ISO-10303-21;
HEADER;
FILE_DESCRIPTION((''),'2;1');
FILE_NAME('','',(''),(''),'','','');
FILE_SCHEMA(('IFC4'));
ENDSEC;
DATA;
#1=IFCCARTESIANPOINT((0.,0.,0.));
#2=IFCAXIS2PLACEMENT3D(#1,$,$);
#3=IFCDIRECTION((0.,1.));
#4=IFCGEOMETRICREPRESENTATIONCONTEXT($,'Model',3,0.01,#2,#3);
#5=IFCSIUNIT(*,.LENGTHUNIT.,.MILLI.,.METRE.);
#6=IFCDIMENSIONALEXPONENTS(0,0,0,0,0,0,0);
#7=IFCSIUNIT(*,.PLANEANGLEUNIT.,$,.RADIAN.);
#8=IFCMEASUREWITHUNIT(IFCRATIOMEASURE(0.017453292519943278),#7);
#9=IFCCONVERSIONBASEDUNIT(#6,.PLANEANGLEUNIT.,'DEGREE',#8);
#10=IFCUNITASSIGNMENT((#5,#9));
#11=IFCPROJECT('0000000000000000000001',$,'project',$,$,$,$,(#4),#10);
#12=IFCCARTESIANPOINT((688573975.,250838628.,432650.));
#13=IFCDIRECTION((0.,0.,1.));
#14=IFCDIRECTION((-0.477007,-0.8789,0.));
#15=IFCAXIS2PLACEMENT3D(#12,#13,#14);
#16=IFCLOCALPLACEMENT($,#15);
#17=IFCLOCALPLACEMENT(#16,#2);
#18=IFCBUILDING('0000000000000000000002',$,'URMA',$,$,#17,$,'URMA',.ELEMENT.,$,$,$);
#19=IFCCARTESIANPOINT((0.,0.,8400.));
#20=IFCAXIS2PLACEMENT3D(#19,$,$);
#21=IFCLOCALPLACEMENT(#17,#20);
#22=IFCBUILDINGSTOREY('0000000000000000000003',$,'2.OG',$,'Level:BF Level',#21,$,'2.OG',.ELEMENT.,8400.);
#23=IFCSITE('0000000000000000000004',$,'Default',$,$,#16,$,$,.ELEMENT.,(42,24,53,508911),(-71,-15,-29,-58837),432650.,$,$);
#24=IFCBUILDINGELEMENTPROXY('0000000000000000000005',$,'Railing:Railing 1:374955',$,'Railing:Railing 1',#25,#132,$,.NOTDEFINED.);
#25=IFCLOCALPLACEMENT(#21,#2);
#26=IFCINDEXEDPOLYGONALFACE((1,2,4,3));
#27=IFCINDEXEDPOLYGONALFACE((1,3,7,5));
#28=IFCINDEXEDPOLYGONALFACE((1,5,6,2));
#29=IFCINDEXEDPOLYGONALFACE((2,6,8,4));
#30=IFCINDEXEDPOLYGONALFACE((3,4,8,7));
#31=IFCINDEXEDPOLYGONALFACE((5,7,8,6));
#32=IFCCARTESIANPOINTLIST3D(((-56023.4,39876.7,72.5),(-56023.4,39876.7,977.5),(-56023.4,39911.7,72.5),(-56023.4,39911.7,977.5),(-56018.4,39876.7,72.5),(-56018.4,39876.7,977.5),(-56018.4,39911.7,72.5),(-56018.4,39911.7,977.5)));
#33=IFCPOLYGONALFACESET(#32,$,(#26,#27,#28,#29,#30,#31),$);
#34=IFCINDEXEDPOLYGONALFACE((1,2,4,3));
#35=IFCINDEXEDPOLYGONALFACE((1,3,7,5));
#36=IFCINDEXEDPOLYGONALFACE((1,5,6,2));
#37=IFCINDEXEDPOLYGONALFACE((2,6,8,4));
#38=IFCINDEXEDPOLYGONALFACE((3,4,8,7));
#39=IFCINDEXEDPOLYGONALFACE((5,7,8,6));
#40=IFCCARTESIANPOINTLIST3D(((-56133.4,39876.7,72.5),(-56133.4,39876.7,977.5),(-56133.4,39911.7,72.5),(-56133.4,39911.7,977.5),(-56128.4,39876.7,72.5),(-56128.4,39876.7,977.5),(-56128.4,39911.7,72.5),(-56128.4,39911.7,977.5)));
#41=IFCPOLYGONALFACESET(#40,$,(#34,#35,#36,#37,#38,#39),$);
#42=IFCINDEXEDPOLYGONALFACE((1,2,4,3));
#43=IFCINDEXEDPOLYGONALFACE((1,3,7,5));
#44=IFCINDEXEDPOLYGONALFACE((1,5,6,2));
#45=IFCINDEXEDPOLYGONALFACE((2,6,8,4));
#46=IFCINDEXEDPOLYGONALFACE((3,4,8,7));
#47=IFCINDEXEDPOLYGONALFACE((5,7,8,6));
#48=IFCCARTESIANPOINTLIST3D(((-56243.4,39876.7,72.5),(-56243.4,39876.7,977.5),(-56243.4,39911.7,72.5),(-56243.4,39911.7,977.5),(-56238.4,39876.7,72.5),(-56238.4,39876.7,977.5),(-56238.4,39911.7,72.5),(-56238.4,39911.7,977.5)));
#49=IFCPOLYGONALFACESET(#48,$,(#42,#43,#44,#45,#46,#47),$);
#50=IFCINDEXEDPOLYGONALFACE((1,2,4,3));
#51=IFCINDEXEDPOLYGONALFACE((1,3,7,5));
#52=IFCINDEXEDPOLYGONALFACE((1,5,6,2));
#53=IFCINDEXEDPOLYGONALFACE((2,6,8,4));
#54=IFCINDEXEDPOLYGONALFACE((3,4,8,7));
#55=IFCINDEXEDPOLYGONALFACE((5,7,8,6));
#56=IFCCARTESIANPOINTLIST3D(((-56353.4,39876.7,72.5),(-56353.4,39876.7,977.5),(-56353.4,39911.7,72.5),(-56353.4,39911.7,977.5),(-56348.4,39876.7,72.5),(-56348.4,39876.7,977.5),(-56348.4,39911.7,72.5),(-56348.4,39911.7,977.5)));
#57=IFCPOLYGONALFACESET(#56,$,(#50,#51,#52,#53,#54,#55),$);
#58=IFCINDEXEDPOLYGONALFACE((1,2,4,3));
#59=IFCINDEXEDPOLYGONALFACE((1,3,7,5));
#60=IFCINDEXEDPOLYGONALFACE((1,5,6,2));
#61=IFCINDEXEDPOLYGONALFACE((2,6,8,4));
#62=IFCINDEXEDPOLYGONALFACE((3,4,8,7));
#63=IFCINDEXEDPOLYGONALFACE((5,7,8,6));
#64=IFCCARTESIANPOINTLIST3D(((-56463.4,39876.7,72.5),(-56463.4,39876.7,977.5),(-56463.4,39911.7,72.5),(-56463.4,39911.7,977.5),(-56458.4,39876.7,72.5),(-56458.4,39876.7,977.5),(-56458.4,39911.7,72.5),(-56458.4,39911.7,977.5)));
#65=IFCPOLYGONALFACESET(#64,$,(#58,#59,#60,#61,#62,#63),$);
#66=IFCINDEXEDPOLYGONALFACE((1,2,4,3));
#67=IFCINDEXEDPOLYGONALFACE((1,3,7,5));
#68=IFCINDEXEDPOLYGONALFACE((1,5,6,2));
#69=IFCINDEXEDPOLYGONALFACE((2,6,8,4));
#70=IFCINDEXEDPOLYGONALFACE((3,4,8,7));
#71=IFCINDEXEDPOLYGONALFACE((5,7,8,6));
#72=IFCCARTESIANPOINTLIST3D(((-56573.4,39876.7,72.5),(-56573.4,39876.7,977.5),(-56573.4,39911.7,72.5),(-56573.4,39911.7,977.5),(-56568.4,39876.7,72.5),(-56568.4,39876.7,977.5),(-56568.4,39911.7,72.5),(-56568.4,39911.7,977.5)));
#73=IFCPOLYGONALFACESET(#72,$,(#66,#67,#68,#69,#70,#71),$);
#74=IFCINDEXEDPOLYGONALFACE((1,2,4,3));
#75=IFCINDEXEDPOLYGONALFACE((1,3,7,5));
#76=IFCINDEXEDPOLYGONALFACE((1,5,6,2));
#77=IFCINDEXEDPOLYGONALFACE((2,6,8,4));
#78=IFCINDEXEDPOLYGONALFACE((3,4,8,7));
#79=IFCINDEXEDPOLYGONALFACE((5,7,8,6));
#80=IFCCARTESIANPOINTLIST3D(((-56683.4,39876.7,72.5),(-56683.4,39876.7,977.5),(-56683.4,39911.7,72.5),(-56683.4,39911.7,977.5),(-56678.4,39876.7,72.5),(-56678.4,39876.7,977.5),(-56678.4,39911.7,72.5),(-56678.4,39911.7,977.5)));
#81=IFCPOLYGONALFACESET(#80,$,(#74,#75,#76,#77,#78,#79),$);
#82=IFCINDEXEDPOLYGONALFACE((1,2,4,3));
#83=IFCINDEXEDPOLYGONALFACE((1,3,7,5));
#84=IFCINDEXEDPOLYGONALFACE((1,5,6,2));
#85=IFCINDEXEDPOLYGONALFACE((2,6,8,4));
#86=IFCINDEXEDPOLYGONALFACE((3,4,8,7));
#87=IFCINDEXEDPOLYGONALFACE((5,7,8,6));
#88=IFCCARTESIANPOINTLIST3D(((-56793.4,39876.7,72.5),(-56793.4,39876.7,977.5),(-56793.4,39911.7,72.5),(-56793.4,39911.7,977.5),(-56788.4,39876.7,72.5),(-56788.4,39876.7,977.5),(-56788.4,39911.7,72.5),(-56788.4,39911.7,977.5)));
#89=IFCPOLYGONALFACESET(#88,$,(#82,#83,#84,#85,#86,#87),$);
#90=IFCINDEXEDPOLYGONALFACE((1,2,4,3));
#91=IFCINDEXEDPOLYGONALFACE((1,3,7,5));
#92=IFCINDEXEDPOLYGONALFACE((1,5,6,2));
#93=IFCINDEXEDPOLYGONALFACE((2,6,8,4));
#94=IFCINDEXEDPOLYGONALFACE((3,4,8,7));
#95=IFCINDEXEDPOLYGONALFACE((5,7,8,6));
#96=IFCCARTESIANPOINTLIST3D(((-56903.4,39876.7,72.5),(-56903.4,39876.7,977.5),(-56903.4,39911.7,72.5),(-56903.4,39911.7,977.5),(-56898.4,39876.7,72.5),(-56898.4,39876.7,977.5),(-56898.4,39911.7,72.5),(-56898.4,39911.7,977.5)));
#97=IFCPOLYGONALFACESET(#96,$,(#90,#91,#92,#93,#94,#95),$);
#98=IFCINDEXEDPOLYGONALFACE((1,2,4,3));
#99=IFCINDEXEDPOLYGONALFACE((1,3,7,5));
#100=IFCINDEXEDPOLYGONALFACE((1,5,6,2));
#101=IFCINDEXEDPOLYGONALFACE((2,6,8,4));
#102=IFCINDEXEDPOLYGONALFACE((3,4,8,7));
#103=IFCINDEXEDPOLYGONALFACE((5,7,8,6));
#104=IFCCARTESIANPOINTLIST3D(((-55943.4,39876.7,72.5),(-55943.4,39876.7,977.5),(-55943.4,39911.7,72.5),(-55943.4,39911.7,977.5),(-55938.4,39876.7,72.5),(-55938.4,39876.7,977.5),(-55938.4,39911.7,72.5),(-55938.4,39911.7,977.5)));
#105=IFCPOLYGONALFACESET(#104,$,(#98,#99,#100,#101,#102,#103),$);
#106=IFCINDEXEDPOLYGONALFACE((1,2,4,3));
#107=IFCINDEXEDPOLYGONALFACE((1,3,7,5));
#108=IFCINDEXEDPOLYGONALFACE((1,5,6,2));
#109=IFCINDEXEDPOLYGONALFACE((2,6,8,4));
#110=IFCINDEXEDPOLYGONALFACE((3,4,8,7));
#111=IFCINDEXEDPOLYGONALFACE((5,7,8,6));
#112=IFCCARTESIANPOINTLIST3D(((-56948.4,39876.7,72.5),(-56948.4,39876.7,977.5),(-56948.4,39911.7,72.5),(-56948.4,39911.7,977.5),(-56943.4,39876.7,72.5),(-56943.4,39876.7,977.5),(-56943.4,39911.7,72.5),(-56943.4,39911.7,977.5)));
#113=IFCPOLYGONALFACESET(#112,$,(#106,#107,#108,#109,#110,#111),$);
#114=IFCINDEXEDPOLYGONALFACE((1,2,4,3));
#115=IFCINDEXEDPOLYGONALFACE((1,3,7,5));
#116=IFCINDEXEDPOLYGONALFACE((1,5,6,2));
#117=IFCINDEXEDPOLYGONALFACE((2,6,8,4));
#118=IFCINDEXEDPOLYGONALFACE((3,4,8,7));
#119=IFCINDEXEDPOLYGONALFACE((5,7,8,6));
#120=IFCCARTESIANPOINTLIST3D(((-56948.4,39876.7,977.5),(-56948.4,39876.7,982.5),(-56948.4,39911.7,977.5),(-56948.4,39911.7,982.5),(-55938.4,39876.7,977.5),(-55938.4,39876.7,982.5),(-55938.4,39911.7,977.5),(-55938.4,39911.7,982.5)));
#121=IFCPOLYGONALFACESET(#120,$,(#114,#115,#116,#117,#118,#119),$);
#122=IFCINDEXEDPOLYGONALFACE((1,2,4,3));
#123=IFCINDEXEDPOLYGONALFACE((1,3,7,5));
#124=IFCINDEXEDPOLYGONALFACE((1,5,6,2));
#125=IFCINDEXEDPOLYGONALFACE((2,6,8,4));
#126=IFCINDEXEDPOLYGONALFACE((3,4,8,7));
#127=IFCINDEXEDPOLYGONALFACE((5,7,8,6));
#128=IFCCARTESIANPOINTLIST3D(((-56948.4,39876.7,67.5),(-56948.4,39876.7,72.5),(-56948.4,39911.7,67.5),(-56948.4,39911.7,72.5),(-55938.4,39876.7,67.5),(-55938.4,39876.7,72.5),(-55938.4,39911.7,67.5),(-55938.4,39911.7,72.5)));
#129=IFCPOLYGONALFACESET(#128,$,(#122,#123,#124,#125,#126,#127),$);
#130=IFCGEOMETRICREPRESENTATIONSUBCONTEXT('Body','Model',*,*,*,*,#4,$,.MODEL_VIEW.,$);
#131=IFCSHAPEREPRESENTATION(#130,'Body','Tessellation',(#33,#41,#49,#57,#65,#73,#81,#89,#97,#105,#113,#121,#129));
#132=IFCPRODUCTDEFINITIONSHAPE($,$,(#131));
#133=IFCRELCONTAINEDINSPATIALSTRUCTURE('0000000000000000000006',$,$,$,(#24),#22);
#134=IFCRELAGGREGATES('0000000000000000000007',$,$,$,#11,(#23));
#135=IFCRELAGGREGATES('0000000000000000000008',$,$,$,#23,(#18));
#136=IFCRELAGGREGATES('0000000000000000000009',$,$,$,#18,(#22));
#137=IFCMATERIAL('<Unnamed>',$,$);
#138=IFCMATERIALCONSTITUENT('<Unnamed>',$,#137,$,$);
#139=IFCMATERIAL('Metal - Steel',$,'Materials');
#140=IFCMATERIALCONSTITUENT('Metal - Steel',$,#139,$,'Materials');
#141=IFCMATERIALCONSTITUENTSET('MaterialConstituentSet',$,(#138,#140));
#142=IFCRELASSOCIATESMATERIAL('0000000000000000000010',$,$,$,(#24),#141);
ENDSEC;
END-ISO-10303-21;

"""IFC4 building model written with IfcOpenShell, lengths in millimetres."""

from ifc_helpers import new_model, entity, si_unit, converted_unit, direction, frame, origin, place, context, subcontext, project, spatial, indexed_curve, outline, extrude, material, constituent, constituent_set, element, save


model = new_model("IFC4")

# Units and contexts
model_context = context("Model", 3, precision=0.01, world=origin(), true_north=direction((0.0, 1.0)))
body_context = subcontext(model_context, "Body", "Model", "MODEL_VIEW")
ifc_project = project(units=[si_unit("LENGTHUNIT", "METRE", prefix="MILLI"), converted_unit("PLANEANGLEUNIT", "DEGREE", entity("IfcRatioMeasure", 0.017453292519943278), si_unit("PLANEANGLEUNIT", "RADIAN"), dimensions=[0, 0, 0, 0, 0, 0, 0])], contexts=[model_context])

# Site, building, storey
site_placement = place(None, frame((688573975.0, 250838628.0, 432650.0), z_axis=(0.0, 0.0, 1.0), x_axis=(-0.477007, -0.8789, 0.0)))
site = spatial("IfcSite", under=ifc_project, at=site_placement, Name="Default", CompositionType="ELEMENT", RefLatitude=(42, 24, 53, 508911), RefLongitude=(-71, -15, -29, -58837), RefElevation=432650.0)
building_placement = place(site_placement, origin())
building = spatial("IfcBuilding", under=site, at=building_placement, Name="URMA", LongName="URMA", CompositionType="ELEMENT")
storey_placement = place(building_placement, frame((0.0, 0.0, 8400.0)))
storey = spatial("IfcBuildingStorey", under=building, at=storey_placement, Name="2.OG", ObjectType="Level:BF Level", LongName="2.OG", CompositionType="ELEMENT", Elevation=8400.0)

# Building element proxy
ifc_material_1 = material(Name="<Unnamed>")
ifc_material_2 = material(Name="Metal - Steel", Category="Materials")
ifc_constituent_1 = constituent(ifc_material_1, Name="<Unnamed>")
ifc_constituent_2 = constituent(ifc_material_2, Name="Metal - Steel", Category="Materials")
ifc_constituent_set_1 = constituent_set(constituents=[ifc_constituent_1, ifc_constituent_2], Name="MaterialConstituentSet")
proxy_1_placement = place(storey_placement, origin())
element("IfcBuildingElementProxy", 1, at=proxy_1_placement, inside=storey, material=ifc_constituent_set_1, Name="Railing:Railing 1:374955", ObjectType="Railing:Railing 1", PredefinedType="NOTDEFINED", context=body_context, shape_type="SweptSolid", body=[
    extrude(outline(indexed_curve([(-17.5, -2.5), (17.5, -2.5), (17.5, 2.5), (-17.5, 2.5), (-17.5, -2.5)], self_intersect=False)), frame((-56020.9, 39894.2, 72.5), z_axis=(0.0, 0.0, 1.0), x_axis=(0.0, 1.0, 0.0)), (0.0, 0.0, 1.0), 905.0),
    extrude(outline(indexed_curve([(-17.5, -2.5), (17.5, -2.5), (17.5, 2.5), (-17.5, 2.5), (-17.5, -2.5)], self_intersect=False)), frame((-56130.9, 39894.2, 72.5), z_axis=(0.0, 0.0, 1.0), x_axis=(0.0, 1.0, 0.0)), (0.0, 0.0, 1.0), 905.0),
    extrude(outline(indexed_curve([(-17.5, -2.5), (17.5, -2.5), (17.5, 2.5), (-17.5, 2.5), (-17.5, -2.5)], self_intersect=False)), frame((-56240.9, 39894.2, 72.5), z_axis=(0.0, 0.0, 1.0), x_axis=(0.0, 1.0, 0.0)), (0.0, 0.0, 1.0), 905.0),
    extrude(outline(indexed_curve([(-17.5, -2.5), (17.5, -2.5), (17.5, 2.5), (-17.5, 2.5), (-17.5, -2.5)], self_intersect=False)), frame((-56350.9, 39894.2, 72.5), z_axis=(0.0, 0.0, 1.0), x_axis=(0.0, 1.0, 0.0)), (0.0, 0.0, 1.0), 905.0),
    extrude(outline(indexed_curve([(-17.5, -2.5), (17.5, -2.5), (17.5, 2.5), (-17.5, 2.5), (-17.5, -2.5)], self_intersect=False)), frame((-56460.9, 39894.2, 72.5), z_axis=(0.0, 0.0, 1.0), x_axis=(0.0, 1.0, 0.0)), (0.0, 0.0, 1.0), 905.0),
    extrude(outline(indexed_curve([(-17.5, -2.5), (17.5, -2.5), (17.5, 2.5), (-17.5, 2.5), (-17.5, -2.5)], self_intersect=False)), frame((-56570.9, 39894.2, 72.5), z_axis=(0.0, 0.0, 1.0), x_axis=(0.0, 1.0, 0.0)), (0.0, 0.0, 1.0), 905.0),
    extrude(outline(indexed_curve([(-17.5, -2.5), (17.5, -2.5), (17.5, 2.5), (-17.5, 2.5), (-17.5, -2.5)], self_intersect=False)), frame((-56680.9, 39894.2, 72.5), z_axis=(0.0, 0.0, 1.0), x_axis=(0.0, 1.0, 0.0)), (0.0, 0.0, 1.0), 905.0),
    extrude(outline(indexed_curve([(-17.5, -2.5), (17.5, -2.5), (17.5, 2.5), (-17.5, 2.5), (-17.5, -2.5)], self_intersect=False)), frame((-56790.9, 39894.2, 72.5), z_axis=(0.0, 0.0, 1.0), x_axis=(0.0, 1.0, 0.0)), (0.0, 0.0, 1.0), 905.0),
    extrude(outline(indexed_curve([(-17.5, -2.5), (17.5, -2.5), (17.5, 2.5), (-17.5, 2.5), (-17.5, -2.5)], self_intersect=False)), frame((-56900.9, 39894.2, 72.5), z_axis=(0.0, 0.0, 1.0), x_axis=(0.0, 1.0, 0.0)), (0.0, 0.0, 1.0), 905.0),
    extrude(outline(indexed_curve([(-17.5, -2.5), (17.5, -2.5), (17.5, 2.5), (-17.5, 2.5), (-17.5, -2.5)], self_intersect=False)), frame((-55940.9, 39894.2, 72.5), z_axis=(0.0, 0.0, 1.0), x_axis=(0.0, 1.0, 0.0)), (0.0, 0.0, 1.0), 905.0),
    extrude(outline(indexed_curve([(-17.5, -2.5), (17.5, -2.5), (17.5, 2.5), (-17.5, 2.5), (-17.5, -2.5)], self_intersect=False)), frame((-56945.9, 39894.2, 72.5), z_axis=(0.0, 0.0, 1.0), x_axis=(0.0, 1.0, 0.0)), (0.0, 0.0, 1.0), 905.0),
    extrude(outline(indexed_curve([(-505.0, -17.5), (505.0, -17.5), (505.0, 17.5), (-505.0, 17.5), (-505.0, -17.5)], self_intersect=False)), frame((-56443.4, 39894.2, 977.5)), (0.0, 0.0, 1.0), 5.0),
    extrude(outline(indexed_curve([(-505.0, -17.5), (505.0, -17.5), (505.0, 17.5), (-505.0, 17.5), (-505.0, -17.5)], self_intersect=False)), frame((-56443.4, 39894.2, 67.5)), (0.0, 0.0, 1.0), 5.0),
])

save(model, "model.ifc")
